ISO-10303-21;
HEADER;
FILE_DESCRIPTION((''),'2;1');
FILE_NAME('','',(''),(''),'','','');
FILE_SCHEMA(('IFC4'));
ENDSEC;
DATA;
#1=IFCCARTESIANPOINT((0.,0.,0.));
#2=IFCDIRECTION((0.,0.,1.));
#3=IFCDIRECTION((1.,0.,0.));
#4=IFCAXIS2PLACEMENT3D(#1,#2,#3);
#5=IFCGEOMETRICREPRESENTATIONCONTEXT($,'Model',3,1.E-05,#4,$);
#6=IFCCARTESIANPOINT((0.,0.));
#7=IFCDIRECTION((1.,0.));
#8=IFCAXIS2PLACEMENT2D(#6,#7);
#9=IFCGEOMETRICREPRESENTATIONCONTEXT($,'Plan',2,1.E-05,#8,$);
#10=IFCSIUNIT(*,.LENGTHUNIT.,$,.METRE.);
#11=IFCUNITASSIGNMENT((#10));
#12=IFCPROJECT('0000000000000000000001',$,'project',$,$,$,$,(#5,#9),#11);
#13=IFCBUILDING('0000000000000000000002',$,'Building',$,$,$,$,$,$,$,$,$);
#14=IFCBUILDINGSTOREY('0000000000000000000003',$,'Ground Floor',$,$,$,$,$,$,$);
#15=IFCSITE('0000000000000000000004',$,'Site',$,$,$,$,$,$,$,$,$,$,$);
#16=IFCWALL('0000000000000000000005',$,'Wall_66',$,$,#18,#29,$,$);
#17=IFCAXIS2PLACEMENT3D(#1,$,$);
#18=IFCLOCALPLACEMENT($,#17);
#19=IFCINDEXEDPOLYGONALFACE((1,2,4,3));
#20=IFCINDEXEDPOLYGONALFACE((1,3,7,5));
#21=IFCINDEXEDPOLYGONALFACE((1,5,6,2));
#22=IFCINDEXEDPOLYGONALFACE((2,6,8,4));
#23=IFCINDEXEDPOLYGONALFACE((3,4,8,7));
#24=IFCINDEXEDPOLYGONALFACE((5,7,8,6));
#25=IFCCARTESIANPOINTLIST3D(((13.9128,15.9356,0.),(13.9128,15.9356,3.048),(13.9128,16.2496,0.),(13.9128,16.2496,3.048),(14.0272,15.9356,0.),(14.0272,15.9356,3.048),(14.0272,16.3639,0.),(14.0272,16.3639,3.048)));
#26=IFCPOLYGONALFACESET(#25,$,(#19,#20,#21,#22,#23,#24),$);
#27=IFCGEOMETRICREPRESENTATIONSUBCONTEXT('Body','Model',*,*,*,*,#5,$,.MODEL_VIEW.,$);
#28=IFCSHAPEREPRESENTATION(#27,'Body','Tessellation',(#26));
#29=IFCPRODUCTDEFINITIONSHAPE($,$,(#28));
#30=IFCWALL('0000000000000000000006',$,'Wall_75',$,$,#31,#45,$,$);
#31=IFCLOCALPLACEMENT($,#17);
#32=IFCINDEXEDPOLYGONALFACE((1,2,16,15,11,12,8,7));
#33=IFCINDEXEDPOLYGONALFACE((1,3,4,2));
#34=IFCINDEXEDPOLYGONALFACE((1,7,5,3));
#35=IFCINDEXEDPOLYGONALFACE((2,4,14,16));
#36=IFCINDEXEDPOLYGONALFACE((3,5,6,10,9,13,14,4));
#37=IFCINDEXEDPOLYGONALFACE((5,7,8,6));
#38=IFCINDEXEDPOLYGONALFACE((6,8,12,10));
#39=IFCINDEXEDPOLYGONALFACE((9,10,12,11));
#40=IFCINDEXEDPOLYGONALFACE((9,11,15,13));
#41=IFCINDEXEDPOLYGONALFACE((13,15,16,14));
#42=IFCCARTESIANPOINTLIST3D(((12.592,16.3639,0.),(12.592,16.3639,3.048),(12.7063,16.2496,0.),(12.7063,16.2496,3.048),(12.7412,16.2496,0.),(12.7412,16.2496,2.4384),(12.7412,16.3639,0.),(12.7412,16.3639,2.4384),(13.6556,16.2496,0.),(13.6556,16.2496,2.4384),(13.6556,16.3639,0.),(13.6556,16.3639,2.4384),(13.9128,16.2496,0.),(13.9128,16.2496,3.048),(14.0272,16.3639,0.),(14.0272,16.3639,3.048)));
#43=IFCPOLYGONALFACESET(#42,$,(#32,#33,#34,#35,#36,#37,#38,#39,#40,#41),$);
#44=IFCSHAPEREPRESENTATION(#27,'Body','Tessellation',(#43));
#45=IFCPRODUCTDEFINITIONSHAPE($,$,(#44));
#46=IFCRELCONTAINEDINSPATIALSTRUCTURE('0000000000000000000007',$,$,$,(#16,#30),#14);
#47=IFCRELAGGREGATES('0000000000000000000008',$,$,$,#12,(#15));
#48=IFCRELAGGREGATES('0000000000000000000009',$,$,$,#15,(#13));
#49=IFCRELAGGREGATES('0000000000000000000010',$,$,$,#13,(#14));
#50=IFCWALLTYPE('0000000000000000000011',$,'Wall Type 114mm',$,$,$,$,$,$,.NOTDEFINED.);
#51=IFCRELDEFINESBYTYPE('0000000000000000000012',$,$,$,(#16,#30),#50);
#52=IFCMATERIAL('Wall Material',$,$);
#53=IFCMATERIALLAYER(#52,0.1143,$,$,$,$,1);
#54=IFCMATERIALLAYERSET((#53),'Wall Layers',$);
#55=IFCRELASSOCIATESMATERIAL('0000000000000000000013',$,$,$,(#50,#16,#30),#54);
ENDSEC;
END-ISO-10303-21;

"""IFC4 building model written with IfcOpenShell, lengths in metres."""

from ifc_helpers import new_model, si_unit, frame, origin_with_axes, origin_2d_with_axis, place, context, subcontext, project, spatial, line, indexed_curve, rectangle, outline, extrude, material, layer, layer_set, layer_usage, type_object, element, save


model = new_model("IFC4")

# Units and contexts
model_context = context("Model", 3, precision=1e-05, world=origin_with_axes())
plan_context = context("Plan", 2, precision=1e-05, world=origin_2d_with_axis())
body_context = subcontext(model_context, "Body", "Model", "MODEL_VIEW")
ifc_project = project(units=[si_unit("LENGTHUNIT", "METRE")], contexts=[model_context, plan_context])

# Site, building, storey
site = spatial("IfcSite", under=ifc_project, Name="Site")
building = spatial("IfcBuilding", under=site, Name="Building")
storey = spatial("IfcBuildingStorey", under=building, Name="Ground Floor")

# Shared definitions
ifc_material_1 = material(Name="Wall Material")
ifc_layer_1 = layer(ifc_material_1, 0.1143, Priority=1)
ifc_layer_set_1 = layer_set([ifc_layer_1], Name="Wall Layers")
wall_type_1 = type_object("IfcWallType", Name="Wall Type 114mm", PredefinedType="NOTDEFINED", material=ifc_layer_set_1)

# Wall
ifc_layer_usage_1 = layer_usage(ifc_layer_set_1, "AXIS2", "POSITIVE", -0.0571)
wall_1_placement = place(None, frame((13.97, 16.3068, 0.0), z_axis=(0.0, 0.0, 1.0), x_axis=(0.0, -1.0, 0.0)))
element("IfcWall", 1, at=wall_1_placement, inside=storey, type_object=wall_type_1, material=ifc_layer_usage_1, Name="Wall_66", context=body_context, shape_type="SweptSolid", body=[
    extrude(outline(indexed_curve([(0.0571, -0.0571), (-0.0571, 0.0571), (0.3712, 0.0571), (0.3712, -0.0571)], segments=[line(1, 2, 3, 4, 1)])), origin_with_axes(), (0.0, 0.0, 1.0), 3.048),
])

# Wall, opening
ifc_layer_usage_2 = layer_usage(ifc_layer_set_1, "AXIS2", "POSITIVE", -0.0571)
wall_2_placement = place(None, frame((13.97, 16.3068, 0.0), z_axis=(0.0, 0.0, 1.0), x_axis=(-1.0, 0.0, 0.0)))
wall_2 = element("IfcWall", 2, at=wall_2_placement, inside=storey, type_object=wall_type_1, material=ifc_layer_usage_2, Name="Wall_75", context=body_context, shape_type="SweptSolid", body=[
    extrude(outline(indexed_curve([(-0.0571, -0.0571), (0.0571, 0.0571), (1.2637, 0.0571), (1.378, -0.0571)], segments=[line(1, 2, 3, 4, 1)])), origin_with_axes(), (0.0, 0.0, 1.0), 3.048),
])
opening_1_placement = place(wall_2_placement, frame((0.7716, 0.0, 0.0), z_axis=(0.0, 0.0, 1.0), x_axis=(1.0, 0.0, 0.0)))
element("IfcOpeningElement", 3, at=opening_1_placement, cuts=wall_2, context=body_context, shape_type="SweptSolid", body=[
    extrude(rectangle(XDim=0.9144, YDim=0.5), None, (0.0, 0.0, 1.0), 2.4384),
])

save(model, "model.ifc")
